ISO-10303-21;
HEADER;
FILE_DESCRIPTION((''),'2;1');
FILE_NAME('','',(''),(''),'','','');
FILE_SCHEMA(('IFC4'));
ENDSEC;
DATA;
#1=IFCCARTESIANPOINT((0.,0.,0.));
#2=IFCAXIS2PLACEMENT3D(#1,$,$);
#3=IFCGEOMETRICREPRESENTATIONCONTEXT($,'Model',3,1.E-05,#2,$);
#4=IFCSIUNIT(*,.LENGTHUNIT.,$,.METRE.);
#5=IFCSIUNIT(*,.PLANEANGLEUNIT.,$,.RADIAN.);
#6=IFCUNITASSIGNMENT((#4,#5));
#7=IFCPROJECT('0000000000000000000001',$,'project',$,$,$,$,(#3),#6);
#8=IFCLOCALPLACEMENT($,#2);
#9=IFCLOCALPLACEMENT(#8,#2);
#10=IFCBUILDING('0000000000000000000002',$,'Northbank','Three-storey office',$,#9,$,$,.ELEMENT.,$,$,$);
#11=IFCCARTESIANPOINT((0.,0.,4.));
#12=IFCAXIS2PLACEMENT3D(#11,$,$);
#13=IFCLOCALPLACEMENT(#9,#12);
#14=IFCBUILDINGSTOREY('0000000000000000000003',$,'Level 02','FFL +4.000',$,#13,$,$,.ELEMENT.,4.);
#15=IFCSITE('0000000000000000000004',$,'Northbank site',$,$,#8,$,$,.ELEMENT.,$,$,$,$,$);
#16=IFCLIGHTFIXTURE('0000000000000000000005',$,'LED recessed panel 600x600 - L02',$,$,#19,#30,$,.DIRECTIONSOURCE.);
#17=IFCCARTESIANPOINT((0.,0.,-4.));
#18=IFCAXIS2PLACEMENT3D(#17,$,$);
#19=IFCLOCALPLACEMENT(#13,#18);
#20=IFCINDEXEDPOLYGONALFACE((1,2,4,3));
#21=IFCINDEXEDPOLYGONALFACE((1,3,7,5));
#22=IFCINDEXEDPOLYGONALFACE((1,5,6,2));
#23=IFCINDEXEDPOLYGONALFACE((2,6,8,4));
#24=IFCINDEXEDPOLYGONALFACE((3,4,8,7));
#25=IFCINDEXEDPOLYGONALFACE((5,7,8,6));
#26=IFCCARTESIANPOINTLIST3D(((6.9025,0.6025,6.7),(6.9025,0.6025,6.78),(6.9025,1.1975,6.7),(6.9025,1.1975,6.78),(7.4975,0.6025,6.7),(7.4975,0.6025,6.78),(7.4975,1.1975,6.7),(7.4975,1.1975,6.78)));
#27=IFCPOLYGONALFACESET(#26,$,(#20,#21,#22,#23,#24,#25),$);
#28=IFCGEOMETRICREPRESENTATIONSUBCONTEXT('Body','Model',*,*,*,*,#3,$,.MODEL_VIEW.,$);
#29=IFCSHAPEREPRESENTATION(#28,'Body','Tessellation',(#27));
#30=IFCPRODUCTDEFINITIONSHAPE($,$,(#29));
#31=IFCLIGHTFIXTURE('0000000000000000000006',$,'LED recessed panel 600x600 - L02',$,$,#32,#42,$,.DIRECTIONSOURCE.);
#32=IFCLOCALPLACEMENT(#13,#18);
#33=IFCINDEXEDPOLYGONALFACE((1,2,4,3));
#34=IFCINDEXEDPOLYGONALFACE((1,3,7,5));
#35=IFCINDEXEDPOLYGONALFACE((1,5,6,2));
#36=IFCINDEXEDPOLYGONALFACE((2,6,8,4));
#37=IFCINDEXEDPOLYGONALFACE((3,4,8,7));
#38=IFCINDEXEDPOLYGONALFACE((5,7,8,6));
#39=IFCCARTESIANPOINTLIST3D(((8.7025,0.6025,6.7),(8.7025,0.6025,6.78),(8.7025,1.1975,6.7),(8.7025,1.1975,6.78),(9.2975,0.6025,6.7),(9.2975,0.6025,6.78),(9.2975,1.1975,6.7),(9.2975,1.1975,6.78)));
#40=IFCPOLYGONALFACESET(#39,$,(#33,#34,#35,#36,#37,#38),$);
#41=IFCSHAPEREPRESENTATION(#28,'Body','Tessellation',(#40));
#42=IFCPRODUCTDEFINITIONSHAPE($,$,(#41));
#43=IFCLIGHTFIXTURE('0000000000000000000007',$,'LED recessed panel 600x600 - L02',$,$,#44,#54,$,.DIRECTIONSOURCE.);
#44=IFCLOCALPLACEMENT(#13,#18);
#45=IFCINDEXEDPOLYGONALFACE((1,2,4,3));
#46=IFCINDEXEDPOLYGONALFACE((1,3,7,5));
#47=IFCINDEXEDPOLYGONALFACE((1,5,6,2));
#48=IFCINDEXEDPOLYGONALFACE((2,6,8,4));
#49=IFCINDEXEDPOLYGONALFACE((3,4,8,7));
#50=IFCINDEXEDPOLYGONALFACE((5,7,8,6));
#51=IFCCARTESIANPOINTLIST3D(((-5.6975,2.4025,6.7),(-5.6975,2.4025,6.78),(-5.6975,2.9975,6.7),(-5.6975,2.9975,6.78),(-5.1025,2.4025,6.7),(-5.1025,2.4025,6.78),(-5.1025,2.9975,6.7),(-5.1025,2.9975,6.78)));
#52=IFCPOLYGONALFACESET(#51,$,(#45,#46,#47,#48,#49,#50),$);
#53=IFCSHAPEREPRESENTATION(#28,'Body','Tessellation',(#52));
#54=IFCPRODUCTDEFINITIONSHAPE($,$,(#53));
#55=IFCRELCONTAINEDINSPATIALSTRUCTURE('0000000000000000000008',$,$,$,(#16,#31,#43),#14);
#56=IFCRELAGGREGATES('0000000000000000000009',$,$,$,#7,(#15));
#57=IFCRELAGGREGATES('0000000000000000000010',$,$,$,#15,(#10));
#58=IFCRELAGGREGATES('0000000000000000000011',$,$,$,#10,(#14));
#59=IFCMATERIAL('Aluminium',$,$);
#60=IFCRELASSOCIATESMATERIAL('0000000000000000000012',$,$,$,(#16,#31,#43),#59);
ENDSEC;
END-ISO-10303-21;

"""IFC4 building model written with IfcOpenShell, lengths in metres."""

from ifc_helpers import new_model, si_unit, frame, origin, place, context, subcontext, project, spatial, rectangle, extrude, material, element, save


model = new_model("IFC4")

# Units and contexts
model_context = context("Model", 3, precision=1e-05, world=origin())
body_context = subcontext(model_context, "Body", "Model", "MODEL_VIEW")
ifc_project = project(units=[si_unit("LENGTHUNIT", "METRE"), si_unit("PLANEANGLEUNIT", "RADIAN")], contexts=[model_context])

# Site, building, storey
site_placement = place(None, origin())
site = spatial("IfcSite", under=ifc_project, at=site_placement, Name="Northbank site", CompositionType="ELEMENT")
building_placement = place(site_placement, origin())
building = spatial("IfcBuilding", under=site, at=building_placement, Name="Northbank", Description="Three-storey office", CompositionType="ELEMENT")
storey_placement = place(building_placement, frame((0.0, 0.0, 4.0)))
storey = spatial("IfcBuildingStorey", under=building, at=storey_placement, Name="Level 02", Description="FFL +4.000", CompositionType="ELEMENT", Elevation=4.0)

# Light fixtures
ifc_material = material(Name="Aluminium")
light_fixture_1_placement = place(storey_placement, frame((0.0, 0.0, -4.0)))
element("IfcLightFixture", 1, at=light_fixture_1_placement, inside=storey, material=ifc_material, Name="LED recessed panel 600x600 - L02", PredefinedType="DIRECTIONSOURCE", context=body_context, shape_type="SweptSolid", body=[
    extrude(rectangle(XDim=0.595, YDim=0.595), frame((7.2, 0.9, 6.7)), (0.0, 0.0, 1.0), 0.08),
])
light_fixture_2_placement = place(storey_placement, frame((0.0, 0.0, -4.0)))
element("IfcLightFixture", 2, at=light_fixture_2_placement, inside=storey, material=ifc_material, Name="LED recessed panel 600x600 - L02", PredefinedType="DIRECTIONSOURCE", context=body_context, shape_type="SweptSolid", body=[
    extrude(rectangle(XDim=0.595, YDim=0.595), frame((9.0, 0.9, 6.7)), (0.0, 0.0, 1.0), 0.08),
])
light_fixture_3_placement = place(storey_placement, frame((0.0, 0.0, -4.0)))
element("IfcLightFixture", 3, at=light_fixture_3_placement, inside=storey, material=ifc_material, Name="LED recessed panel 600x600 - L02", PredefinedType="DIRECTIONSOURCE", context=body_context, shape_type="SweptSolid", body=[
    extrude(rectangle(XDim=0.595, YDim=0.595), frame((-5.4, 2.7, 6.7)), (0.0, 0.0, 1.0), 0.08),
])

save(model, "model.ifc")
